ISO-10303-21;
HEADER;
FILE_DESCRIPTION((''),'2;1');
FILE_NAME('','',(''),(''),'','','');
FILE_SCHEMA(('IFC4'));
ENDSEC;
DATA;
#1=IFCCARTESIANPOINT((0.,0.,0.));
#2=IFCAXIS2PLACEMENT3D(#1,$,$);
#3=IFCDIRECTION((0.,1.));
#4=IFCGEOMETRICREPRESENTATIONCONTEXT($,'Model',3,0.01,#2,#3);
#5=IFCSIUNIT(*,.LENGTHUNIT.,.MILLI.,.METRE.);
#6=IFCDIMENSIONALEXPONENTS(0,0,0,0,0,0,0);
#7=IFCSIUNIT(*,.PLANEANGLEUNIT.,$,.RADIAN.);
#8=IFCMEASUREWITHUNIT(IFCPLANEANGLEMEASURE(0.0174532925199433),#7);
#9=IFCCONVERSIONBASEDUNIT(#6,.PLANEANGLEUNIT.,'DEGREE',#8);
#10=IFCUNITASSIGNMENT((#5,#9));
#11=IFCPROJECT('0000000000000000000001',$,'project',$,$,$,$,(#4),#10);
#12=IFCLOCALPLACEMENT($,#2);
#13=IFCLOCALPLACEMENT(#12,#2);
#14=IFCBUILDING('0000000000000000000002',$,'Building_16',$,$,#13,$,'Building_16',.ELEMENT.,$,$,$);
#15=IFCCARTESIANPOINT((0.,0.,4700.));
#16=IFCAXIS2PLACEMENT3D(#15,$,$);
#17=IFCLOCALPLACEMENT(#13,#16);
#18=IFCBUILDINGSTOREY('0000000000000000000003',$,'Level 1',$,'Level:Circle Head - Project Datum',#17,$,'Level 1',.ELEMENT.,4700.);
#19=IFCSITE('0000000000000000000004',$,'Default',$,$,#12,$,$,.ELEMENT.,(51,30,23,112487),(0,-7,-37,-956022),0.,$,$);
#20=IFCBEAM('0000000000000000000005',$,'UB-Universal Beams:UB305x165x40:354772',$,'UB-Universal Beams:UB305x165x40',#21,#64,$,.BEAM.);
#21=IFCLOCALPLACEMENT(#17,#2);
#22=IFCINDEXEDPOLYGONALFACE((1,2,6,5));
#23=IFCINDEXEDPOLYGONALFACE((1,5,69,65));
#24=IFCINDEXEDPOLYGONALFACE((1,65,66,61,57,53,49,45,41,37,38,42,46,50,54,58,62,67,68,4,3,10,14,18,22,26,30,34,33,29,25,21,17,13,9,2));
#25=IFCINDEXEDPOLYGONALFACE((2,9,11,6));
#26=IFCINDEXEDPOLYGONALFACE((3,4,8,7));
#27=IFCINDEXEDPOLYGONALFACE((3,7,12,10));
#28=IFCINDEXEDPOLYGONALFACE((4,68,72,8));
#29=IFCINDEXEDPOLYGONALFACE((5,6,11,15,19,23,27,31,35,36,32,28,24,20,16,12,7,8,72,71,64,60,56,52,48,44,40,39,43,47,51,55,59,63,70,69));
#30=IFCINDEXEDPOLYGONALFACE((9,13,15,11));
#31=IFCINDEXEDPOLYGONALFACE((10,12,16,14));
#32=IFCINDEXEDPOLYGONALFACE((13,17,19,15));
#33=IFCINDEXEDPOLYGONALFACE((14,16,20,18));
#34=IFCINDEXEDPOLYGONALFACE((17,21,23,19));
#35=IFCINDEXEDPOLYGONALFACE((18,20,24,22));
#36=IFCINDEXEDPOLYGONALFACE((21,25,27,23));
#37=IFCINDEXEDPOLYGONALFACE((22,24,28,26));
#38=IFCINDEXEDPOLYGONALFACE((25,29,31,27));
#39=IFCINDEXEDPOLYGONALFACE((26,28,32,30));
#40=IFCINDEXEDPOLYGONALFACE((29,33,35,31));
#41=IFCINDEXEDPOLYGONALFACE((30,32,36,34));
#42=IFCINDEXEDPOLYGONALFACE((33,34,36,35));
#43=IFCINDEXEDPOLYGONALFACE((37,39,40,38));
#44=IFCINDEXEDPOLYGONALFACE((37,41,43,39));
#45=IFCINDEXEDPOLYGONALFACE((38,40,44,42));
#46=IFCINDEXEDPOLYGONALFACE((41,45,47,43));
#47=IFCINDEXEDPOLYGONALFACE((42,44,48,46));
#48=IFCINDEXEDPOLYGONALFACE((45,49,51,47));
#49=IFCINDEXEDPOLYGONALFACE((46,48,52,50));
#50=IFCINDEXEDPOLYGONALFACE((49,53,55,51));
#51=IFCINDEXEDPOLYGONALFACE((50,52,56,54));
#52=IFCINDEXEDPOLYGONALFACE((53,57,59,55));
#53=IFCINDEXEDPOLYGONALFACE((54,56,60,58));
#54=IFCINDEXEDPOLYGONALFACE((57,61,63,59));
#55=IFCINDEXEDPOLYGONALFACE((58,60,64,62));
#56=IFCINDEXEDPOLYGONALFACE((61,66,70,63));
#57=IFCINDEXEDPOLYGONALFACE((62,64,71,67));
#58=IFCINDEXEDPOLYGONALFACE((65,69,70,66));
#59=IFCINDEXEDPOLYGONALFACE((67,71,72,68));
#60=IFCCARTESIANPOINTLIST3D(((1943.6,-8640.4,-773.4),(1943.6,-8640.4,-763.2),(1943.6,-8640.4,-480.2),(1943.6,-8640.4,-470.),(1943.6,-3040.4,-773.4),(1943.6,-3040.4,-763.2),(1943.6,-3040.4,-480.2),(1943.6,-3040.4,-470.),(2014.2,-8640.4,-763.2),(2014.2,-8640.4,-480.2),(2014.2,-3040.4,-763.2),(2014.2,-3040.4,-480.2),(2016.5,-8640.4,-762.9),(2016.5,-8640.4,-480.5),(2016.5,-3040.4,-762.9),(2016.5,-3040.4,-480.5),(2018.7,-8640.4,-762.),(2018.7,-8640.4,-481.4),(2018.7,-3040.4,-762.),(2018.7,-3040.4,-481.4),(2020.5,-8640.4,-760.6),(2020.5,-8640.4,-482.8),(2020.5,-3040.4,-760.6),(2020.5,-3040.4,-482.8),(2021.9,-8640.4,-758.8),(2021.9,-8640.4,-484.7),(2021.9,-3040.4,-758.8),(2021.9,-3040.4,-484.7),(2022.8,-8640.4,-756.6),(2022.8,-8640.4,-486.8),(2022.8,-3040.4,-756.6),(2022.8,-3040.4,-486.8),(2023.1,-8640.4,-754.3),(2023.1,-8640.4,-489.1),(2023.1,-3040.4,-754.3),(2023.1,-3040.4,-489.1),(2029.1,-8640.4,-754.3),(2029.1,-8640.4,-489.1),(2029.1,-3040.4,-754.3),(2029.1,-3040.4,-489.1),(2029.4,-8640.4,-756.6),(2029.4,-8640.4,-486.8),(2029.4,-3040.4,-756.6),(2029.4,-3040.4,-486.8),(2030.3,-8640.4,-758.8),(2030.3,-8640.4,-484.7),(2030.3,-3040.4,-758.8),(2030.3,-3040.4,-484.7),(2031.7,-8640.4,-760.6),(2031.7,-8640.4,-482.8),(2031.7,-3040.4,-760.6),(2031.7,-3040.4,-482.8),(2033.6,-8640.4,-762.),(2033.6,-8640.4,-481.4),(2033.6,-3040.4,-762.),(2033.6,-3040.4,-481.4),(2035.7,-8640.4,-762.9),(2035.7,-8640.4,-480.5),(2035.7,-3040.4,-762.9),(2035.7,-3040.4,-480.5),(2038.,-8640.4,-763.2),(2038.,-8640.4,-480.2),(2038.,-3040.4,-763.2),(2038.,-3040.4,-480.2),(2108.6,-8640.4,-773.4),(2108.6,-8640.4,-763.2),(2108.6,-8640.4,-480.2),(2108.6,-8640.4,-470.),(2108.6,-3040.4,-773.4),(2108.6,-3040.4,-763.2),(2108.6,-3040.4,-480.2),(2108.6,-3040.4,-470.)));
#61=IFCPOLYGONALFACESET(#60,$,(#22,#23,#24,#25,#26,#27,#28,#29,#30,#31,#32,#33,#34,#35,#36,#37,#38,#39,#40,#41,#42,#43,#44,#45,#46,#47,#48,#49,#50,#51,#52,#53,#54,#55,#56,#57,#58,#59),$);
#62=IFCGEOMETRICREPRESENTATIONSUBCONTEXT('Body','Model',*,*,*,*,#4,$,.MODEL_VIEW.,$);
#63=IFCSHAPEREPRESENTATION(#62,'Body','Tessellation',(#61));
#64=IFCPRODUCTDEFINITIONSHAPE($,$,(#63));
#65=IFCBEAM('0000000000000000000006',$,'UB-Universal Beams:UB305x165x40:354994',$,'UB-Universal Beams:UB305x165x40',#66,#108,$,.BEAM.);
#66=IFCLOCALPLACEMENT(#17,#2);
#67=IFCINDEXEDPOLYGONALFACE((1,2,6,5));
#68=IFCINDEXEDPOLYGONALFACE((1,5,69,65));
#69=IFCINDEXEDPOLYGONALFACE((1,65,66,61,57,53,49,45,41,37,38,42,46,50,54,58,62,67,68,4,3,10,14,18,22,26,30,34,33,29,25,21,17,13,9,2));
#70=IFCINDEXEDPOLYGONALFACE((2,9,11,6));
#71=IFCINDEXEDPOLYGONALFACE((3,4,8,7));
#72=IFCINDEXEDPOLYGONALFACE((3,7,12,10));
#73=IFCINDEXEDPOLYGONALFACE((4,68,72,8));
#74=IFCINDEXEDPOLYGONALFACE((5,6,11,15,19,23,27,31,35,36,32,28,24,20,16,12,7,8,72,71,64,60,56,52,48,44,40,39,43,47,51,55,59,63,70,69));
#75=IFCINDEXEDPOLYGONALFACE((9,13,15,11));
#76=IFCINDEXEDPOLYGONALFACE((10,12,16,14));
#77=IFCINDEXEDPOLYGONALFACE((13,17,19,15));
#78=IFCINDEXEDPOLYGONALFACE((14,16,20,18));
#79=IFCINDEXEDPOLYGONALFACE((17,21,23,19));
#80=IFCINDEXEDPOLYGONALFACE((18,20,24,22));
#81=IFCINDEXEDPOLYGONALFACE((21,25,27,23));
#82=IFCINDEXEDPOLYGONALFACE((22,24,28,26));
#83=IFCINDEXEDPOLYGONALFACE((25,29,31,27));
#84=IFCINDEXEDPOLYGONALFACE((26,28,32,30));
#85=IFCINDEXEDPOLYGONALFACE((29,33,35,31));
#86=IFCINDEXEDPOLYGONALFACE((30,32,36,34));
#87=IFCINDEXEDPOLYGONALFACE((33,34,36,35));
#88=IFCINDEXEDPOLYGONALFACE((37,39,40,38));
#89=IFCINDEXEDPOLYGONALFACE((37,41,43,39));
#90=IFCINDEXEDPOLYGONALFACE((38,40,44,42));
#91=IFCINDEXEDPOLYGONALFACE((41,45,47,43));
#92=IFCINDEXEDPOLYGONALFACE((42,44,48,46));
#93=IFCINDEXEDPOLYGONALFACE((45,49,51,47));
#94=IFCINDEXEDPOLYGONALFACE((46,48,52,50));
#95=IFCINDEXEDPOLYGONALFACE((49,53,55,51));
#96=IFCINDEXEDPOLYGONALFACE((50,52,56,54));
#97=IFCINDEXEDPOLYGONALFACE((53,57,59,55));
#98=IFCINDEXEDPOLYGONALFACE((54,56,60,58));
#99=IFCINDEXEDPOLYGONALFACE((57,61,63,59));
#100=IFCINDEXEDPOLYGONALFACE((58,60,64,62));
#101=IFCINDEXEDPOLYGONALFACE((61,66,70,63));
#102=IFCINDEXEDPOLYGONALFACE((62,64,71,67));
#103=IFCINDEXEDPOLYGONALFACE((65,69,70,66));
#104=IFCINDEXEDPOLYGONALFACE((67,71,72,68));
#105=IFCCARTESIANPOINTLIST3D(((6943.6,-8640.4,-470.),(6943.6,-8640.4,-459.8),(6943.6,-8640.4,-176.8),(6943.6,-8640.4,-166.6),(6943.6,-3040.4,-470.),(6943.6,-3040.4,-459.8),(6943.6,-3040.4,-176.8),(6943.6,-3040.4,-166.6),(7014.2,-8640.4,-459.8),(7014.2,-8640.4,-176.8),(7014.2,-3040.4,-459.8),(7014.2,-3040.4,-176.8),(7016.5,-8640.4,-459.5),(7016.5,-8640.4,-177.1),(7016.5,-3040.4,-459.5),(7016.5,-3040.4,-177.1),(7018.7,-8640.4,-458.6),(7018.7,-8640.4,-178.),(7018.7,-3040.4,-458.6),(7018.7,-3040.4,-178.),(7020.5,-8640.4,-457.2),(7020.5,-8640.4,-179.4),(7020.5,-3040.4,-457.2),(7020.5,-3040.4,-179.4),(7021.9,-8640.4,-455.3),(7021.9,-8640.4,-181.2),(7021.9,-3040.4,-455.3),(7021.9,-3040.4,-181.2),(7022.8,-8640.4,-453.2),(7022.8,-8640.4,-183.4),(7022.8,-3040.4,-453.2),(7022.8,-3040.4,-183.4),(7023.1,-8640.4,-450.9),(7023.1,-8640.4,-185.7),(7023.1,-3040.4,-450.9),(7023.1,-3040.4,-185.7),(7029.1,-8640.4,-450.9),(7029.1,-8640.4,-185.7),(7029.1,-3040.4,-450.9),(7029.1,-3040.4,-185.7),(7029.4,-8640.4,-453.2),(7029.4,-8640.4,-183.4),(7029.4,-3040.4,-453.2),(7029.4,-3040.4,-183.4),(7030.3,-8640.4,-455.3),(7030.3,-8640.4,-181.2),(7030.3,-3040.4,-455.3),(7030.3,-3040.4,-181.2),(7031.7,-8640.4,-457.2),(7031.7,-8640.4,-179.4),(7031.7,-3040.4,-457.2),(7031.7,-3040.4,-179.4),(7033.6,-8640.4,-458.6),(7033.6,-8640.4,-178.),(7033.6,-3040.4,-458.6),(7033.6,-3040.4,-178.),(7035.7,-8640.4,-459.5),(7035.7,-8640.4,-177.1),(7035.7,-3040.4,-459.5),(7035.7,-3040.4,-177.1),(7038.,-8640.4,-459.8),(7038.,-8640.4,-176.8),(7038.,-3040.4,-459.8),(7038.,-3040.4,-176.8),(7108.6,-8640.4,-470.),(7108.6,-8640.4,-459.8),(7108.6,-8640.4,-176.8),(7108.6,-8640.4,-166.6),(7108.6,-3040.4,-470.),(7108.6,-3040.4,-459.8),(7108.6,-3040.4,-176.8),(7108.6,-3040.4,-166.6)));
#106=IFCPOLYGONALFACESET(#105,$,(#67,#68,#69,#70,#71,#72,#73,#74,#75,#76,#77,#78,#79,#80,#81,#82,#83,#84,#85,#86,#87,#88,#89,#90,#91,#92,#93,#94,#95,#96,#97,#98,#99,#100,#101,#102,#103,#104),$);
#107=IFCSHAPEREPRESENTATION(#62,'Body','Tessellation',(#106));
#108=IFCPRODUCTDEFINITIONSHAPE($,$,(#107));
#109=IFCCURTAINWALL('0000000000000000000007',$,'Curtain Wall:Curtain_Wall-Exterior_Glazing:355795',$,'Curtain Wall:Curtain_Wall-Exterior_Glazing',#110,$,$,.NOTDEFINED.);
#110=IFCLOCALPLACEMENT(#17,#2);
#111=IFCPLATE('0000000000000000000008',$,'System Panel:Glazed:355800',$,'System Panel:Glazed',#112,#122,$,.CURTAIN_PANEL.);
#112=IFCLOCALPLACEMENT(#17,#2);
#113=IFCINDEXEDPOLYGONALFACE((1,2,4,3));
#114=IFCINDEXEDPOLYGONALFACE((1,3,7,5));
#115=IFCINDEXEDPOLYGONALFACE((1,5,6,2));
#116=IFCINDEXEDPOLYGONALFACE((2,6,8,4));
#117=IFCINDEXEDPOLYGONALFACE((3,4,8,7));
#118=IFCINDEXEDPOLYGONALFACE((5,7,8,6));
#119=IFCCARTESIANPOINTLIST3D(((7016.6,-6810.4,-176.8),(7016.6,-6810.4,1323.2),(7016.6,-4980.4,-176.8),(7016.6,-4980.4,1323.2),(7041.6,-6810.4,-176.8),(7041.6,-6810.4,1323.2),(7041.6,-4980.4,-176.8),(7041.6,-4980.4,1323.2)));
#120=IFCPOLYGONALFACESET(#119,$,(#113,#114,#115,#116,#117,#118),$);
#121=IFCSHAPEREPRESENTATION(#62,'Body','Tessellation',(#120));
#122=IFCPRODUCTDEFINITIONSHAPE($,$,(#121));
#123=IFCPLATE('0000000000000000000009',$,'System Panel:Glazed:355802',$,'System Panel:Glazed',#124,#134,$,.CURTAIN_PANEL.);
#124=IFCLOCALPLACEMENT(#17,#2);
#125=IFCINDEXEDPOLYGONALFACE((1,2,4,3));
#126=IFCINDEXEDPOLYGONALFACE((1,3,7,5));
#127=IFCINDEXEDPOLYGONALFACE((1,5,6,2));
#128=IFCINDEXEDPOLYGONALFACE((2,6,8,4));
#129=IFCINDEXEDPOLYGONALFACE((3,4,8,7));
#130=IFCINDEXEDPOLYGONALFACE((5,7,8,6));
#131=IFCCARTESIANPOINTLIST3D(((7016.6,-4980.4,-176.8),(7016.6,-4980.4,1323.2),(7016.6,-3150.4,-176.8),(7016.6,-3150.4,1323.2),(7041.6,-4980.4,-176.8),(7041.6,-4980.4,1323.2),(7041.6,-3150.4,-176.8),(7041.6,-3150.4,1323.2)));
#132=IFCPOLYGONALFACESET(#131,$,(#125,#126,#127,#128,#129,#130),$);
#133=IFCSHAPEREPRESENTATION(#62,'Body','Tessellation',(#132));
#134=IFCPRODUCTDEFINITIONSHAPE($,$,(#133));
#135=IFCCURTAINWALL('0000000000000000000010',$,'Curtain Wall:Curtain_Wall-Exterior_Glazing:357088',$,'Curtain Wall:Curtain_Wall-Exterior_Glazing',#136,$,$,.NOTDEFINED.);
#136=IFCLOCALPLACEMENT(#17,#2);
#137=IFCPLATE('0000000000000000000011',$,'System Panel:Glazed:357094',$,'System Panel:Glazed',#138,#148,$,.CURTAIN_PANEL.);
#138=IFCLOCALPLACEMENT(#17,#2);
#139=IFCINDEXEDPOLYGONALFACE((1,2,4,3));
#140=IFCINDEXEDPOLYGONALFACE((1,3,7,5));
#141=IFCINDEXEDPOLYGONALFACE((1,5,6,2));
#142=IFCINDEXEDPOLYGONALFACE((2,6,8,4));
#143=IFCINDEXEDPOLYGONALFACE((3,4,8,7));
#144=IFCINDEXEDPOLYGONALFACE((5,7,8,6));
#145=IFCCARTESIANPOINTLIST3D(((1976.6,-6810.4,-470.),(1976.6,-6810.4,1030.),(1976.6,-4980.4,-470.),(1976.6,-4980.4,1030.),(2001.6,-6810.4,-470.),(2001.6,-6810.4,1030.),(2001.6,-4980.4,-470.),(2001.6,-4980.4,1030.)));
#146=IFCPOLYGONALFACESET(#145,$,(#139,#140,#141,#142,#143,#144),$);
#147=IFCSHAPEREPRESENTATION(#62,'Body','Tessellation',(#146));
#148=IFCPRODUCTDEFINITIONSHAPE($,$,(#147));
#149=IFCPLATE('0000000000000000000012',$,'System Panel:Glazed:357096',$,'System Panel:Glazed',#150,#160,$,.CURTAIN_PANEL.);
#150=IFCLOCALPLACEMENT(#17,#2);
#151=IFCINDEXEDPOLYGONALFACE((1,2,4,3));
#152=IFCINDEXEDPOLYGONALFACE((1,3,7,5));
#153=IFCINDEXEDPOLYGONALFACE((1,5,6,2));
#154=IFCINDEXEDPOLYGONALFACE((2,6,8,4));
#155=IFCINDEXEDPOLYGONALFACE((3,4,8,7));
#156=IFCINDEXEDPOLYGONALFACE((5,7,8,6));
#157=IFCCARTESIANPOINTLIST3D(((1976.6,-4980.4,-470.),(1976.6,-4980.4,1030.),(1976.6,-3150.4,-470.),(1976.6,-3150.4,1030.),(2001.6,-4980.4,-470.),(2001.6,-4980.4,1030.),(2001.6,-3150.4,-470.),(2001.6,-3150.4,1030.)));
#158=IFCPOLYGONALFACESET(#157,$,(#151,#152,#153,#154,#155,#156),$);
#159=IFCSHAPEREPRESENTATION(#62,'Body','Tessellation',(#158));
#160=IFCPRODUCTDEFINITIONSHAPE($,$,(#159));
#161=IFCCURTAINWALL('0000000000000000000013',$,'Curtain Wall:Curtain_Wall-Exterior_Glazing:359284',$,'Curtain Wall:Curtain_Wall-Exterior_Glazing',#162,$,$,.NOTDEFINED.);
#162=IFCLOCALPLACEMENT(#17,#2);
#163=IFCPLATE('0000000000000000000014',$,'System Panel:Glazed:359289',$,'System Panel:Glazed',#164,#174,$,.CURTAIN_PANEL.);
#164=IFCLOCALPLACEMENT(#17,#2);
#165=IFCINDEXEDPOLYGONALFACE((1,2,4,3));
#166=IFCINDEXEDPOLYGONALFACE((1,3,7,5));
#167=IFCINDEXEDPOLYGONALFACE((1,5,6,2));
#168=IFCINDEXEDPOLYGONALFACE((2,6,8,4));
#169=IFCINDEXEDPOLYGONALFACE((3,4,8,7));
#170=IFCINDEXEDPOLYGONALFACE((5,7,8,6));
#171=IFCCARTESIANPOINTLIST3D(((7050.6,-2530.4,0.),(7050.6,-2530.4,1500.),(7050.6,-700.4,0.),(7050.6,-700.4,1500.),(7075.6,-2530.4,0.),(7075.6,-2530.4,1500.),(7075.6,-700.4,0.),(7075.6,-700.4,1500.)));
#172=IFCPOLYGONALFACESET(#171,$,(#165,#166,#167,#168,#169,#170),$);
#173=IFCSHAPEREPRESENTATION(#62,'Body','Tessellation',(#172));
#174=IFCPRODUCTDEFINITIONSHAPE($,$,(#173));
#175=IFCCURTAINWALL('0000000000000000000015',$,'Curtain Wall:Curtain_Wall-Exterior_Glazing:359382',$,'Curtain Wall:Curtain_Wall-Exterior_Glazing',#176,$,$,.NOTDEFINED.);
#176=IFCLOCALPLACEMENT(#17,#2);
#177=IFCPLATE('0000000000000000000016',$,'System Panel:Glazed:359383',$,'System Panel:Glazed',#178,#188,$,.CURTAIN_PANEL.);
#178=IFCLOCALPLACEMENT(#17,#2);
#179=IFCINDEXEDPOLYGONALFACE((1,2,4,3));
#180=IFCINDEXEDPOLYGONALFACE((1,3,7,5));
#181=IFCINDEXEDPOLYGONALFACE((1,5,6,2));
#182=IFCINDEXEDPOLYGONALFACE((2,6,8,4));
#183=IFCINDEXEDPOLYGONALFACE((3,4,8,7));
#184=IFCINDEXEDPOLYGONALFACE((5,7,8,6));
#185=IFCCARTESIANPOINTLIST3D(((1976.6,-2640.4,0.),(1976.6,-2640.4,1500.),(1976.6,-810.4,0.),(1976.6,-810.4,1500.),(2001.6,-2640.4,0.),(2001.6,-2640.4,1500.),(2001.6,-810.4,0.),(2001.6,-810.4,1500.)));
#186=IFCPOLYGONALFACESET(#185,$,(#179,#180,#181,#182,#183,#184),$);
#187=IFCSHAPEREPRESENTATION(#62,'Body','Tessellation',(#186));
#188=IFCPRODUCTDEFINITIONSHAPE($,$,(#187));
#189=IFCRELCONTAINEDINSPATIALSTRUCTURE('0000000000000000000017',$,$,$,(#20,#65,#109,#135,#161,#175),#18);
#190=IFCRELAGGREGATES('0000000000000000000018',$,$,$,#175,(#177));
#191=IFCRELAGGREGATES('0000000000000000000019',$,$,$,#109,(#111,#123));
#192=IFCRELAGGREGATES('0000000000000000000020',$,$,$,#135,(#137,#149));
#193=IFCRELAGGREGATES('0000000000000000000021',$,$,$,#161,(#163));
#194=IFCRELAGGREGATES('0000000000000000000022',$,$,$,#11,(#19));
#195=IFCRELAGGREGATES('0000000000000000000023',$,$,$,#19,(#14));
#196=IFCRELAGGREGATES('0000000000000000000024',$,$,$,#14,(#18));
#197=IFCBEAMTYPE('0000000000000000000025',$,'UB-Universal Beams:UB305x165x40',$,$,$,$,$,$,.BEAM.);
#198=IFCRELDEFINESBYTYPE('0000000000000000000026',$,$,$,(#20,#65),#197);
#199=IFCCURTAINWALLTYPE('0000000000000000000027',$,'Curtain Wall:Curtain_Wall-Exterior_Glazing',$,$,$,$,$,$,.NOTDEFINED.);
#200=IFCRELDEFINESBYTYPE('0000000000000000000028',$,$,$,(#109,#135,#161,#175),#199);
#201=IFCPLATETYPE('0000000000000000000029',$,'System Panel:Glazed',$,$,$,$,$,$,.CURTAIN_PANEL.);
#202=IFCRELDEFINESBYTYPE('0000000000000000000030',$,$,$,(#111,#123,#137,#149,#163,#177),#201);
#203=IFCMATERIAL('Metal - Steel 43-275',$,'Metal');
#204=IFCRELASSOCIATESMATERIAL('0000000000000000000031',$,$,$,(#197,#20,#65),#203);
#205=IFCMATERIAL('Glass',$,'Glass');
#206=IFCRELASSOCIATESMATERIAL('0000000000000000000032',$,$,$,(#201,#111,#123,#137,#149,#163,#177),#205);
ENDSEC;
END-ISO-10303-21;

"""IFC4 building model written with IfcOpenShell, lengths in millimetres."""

from ifc_helpers import new_model, entity, si_unit, converted_unit, direction, frame, origin, place, context, subcontext, project, spatial, line, arc, indexed_curve, outline, extrude, source, transform, mapped, material, type_object, type_shapes, element, aggregate, save


model = new_model("IFC4")

# Units and contexts
model_context = context("Model", 3, precision=0.01, world=origin(), true_north=direction((0.0, 1.0)))
body_context = subcontext(model_context, "Body", "Model", "MODEL_VIEW")
ifc_project = project(units=[si_unit("LENGTHUNIT", "METRE", prefix="MILLI"), converted_unit("PLANEANGLEUNIT", "DEGREE", entity("IfcPlaneAngleMeasure", 0.0174532925199433), si_unit("PLANEANGLEUNIT", "RADIAN"), dimensions=[0, 0, 0, 0, 0, 0, 0])], contexts=[model_context])

# Site, building, storey
site_placement = place(None, origin())
site = spatial("IfcSite", under=ifc_project, at=site_placement, Name="Default", CompositionType="ELEMENT", RefLatitude=(51, 30, 23, 112487), RefLongitude=(0, -7, -37, -956022), RefElevation=0.0)
building_placement = place(site_placement, origin())
building = spatial("IfcBuilding", under=site, at=building_placement, Name="Building_16", LongName="Building_16", CompositionType="ELEMENT")
storey_placement = place(building_placement, frame((0.0, 0.0, 4700.0)))
storey = spatial("IfcBuildingStorey", under=building, at=storey_placement, Name="Level 1", ObjectType="Level:Circle Head - Project Datum", LongName="Level 1", CompositionType="ELEMENT", Elevation=4700.0)

# Beams
ifc_material_1 = material(Name="Metal - Steel 43-275", Category="Metal")
beam_type = type_object("IfcBeamType", Name="UB-Universal Beams:UB305x165x40", PredefinedType="BEAM", material=ifc_material_1)
shared_shape_1 = source(origin(), body_context, "Body", "SweptSolid", [
    extrude(outline(indexed_curve([(-82.5, -141.5), (-82.5, -151.7), (82.5, -151.7), (82.5, -141.5), (11.9, -141.5), (5.6, -138.9), (3.0, -132.6), (3.0, 132.6), (5.6, 138.9), (11.9, 141.5), (82.5, 141.5), (82.5, 151.7), (-82.5, 151.7), (-82.5, 141.5), (-11.9, 141.5), (-5.6, 138.9), (-3.0, 132.6), (-3.0, -132.6), (-5.6, -138.9), (-11.9, -141.5)], segments=[line(1, 2, 3, 4, 5), arc(5, 6, 7), line(7, 8), arc(8, 9, 10), line(10, 11, 12, 13, 14, 15), arc(15, 16, 17), line(17, 18), arc(18, 19, 20), line(20, 1)], self_intersect=False)), frame((-2800.0, 0.0, 0.0), z_axis=(-1.0, 0.0, 0.0), x_axis=(0.0, -1.0, 0.0)), (0.0, 0.0, -1.0), 5600.0),
])
type_shapes(beam_type, [shared_shape_1])
for number, where, z_axis, x_axis, name in (
    (1, (2026.1, -5840.4, -621.7), (0.0, 0.0, 1.0), (0.0, 1.0, 0.0), "UB-Universal Beams:UB305x165x40:354772"),
    (2, (7026.1, -5840.4, -318.3), (0.0, 0.0, 1.0), (0.0, -1.0, 0.0), "UB-Universal Beams:UB305x165x40:354994"),
):
    element("IfcBeam", number, at=place(storey_placement, frame(where, z_axis=z_axis, x_axis=x_axis)), inside=storey, type_object=beam_type, material=ifc_material_1, Name=name, ObjectType="UB-Universal Beams:UB305x165x40", PredefinedType="BEAM", context=body_context, shape_type="MappedRepresentation", body=[
        mapped(shared_shape_1, transform((0.0, 0.0, 0.0), scale=1.0)),
    ])

# Curtain walls, plates
curtain_wall_type = type_object("IfcCurtainWallType", Name="Curtain Wall:Curtain_Wall-Exterior_Glazing", PredefinedType="NOTDEFINED")
curtain_wall_1_placement = place(storey_placement, frame((0.0, 0.0, -4700.0)))
curtain_wall_1 = element("IfcCurtainWall", 3, at=curtain_wall_1_placement, inside=storey, type_object=curtain_wall_type, Name="Curtain Wall:Curtain_Wall-Exterior_Glazing:355795", ObjectType="Curtain Wall:Curtain_Wall-Exterior_Glazing", PredefinedType="NOTDEFINED")
ifc_material_2 = material(Name="Glass", Category="Glass")
plate_type_1 = type_object("IfcPlateType", Name="System Panel:Glazed", PredefinedType="CURTAIN_PANEL", material=ifc_material_2)
shared_shape_2 = source(origin(), body_context, "Body", "SweptSolid", [
    extrude(outline(indexed_curve([(-12.5, -915.0), (12.5, -915.0), (12.5, 915.0), (-12.5, 915.0), (-12.5, -915.0)], self_intersect=False)), frame((0.0, 37.0, 0.0), z_axis=(0.0, 0.0, 1.0), x_axis=(0.0, 1.0, 0.0)), (0.0, 0.0, 1.0), 1500.0),
])
type_shapes(plate_type_1, [shared_shape_2])
plate_1_placement = place(curtain_wall_1_placement, frame((7066.1, -5895.4, 4523.2), z_axis=(0.0, 0.0, 1.0), x_axis=(0.0, 1.0, 0.0)))
plate_1 = element("IfcPlate", 4, at=plate_1_placement, type_object=plate_type_1, material=ifc_material_2, Name="System Panel:Glazed:355800", ObjectType="System Panel:Glazed", PredefinedType="CURTAIN_PANEL", context=body_context, shape_type="MappedRepresentation", body=[
    mapped(shared_shape_2, transform((0.0, 0.0, 0.0), scale=1.0)),
])
plate_2_placement = place(curtain_wall_1_placement, frame((7066.1, -4065.4, 4523.2), z_axis=(0.0, 0.0, 1.0), x_axis=(0.0, 1.0, 0.0)))
plate_2 = element("IfcPlate", 5, at=plate_2_placement, type_object=plate_type_1, material=ifc_material_2, Name="System Panel:Glazed:355802", ObjectType="System Panel:Glazed", PredefinedType="CURTAIN_PANEL", context=body_context, shape_type="MappedRepresentation", body=[
    mapped(shared_shape_2, transform((0.0, 0.0, 0.0), scale=1.0)),
])
curtain_wall_2_placement = place(storey_placement, frame((0.0, 0.0, -4700.0)))
curtain_wall_2 = element("IfcCurtainWall", 6, at=curtain_wall_2_placement, inside=storey, type_object=curtain_wall_type, Name="Curtain Wall:Curtain_Wall-Exterior_Glazing:357088", ObjectType="Curtain Wall:Curtain_Wall-Exterior_Glazing", PredefinedType="NOTDEFINED")
plate_3_placement = place(curtain_wall_2_placement, frame((2026.1, -5895.4, 4230.0), z_axis=(0.0, 0.0, 1.0), x_axis=(0.0, 1.0, 0.0)))
plate_3 = element("IfcPlate", 7, at=plate_3_placement, type_object=plate_type_1, material=ifc_material_2, Name="System Panel:Glazed:357094", ObjectType="System Panel:Glazed", PredefinedType="CURTAIN_PANEL", context=body_context, shape_type="MappedRepresentation", body=[
    mapped(shared_shape_2, transform((0.0, 0.0, 0.0), scale=1.0)),
])
plate_4_placement = place(curtain_wall_2_placement, frame((2026.1, -4065.4, 4230.0), z_axis=(0.0, 0.0, 1.0), x_axis=(0.0, 1.0, 0.0)))
plate_4 = element("IfcPlate", 8, at=plate_4_placement, type_object=plate_type_1, material=ifc_material_2, Name="System Panel:Glazed:357096", ObjectType="System Panel:Glazed", PredefinedType="CURTAIN_PANEL", context=body_context, shape_type="MappedRepresentation", body=[
    mapped(shared_shape_2, transform((0.0, 0.0, 0.0), scale=1.0)),
])

# Curtain walls, plates
curtain_wall_3_placement = place(storey_placement, frame((0.0, 0.0, -4700.0)))
curtain_wall_3 = element("IfcCurtainWall", 9, at=curtain_wall_3_placement, inside=storey, type_object=curtain_wall_type, Name="Curtain Wall:Curtain_Wall-Exterior_Glazing:359284", ObjectType="Curtain Wall:Curtain_Wall-Exterior_Glazing", PredefinedType="NOTDEFINED")
plate_5_placement = place(curtain_wall_3_placement, frame((7026.1, -1615.4, 4700.0), z_axis=(0.0, 0.0, 1.0), x_axis=(0.0, -1.0, 0.0)))
plate_5 = element("IfcPlate", 10, at=plate_5_placement, type_object=plate_type_1, material=ifc_material_2, Name="System Panel:Glazed:359289", ObjectType="System Panel:Glazed", PredefinedType="CURTAIN_PANEL", context=body_context, shape_type="MappedRepresentation", body=[
    mapped(shared_shape_2, transform((0.0, 0.0, 0.0), scale=1.0)),
])
curtain_wall_4_placement = place(storey_placement, frame((0.0, 0.0, -4700.0)))
curtain_wall_4 = element("IfcCurtainWall", 11, at=curtain_wall_4_placement, inside=storey, type_object=curtain_wall_type, Name="Curtain Wall:Curtain_Wall-Exterior_Glazing:359382", ObjectType="Curtain Wall:Curtain_Wall-Exterior_Glazing", PredefinedType="NOTDEFINED")
plate_6_placement = place(curtain_wall_4_placement, frame((2026.1, -1725.4, 4700.0), z_axis=(0.0, 0.0, 1.0), x_axis=(0.0, 1.0, 0.0)))
plate_6 = element("IfcPlate", 12, at=plate_6_placement, type_object=plate_type_1, material=ifc_material_2, Name="System Panel:Glazed:359383", ObjectType="System Panel:Glazed", PredefinedType="CURTAIN_PANEL", context=body_context, shape_type="MappedRepresentation", body=[
    mapped(shared_shape_2, transform((0.0, 0.0, 0.0), scale=1.0)),
])
aggregate(curtain_wall_4, [plate_6])

aggregate(curtain_wall_1, [plate_1, plate_2])
aggregate(curtain_wall_2, [plate_3, plate_4])
aggregate(curtain_wall_3, [plate_5])

save(model, "model.ifc")
